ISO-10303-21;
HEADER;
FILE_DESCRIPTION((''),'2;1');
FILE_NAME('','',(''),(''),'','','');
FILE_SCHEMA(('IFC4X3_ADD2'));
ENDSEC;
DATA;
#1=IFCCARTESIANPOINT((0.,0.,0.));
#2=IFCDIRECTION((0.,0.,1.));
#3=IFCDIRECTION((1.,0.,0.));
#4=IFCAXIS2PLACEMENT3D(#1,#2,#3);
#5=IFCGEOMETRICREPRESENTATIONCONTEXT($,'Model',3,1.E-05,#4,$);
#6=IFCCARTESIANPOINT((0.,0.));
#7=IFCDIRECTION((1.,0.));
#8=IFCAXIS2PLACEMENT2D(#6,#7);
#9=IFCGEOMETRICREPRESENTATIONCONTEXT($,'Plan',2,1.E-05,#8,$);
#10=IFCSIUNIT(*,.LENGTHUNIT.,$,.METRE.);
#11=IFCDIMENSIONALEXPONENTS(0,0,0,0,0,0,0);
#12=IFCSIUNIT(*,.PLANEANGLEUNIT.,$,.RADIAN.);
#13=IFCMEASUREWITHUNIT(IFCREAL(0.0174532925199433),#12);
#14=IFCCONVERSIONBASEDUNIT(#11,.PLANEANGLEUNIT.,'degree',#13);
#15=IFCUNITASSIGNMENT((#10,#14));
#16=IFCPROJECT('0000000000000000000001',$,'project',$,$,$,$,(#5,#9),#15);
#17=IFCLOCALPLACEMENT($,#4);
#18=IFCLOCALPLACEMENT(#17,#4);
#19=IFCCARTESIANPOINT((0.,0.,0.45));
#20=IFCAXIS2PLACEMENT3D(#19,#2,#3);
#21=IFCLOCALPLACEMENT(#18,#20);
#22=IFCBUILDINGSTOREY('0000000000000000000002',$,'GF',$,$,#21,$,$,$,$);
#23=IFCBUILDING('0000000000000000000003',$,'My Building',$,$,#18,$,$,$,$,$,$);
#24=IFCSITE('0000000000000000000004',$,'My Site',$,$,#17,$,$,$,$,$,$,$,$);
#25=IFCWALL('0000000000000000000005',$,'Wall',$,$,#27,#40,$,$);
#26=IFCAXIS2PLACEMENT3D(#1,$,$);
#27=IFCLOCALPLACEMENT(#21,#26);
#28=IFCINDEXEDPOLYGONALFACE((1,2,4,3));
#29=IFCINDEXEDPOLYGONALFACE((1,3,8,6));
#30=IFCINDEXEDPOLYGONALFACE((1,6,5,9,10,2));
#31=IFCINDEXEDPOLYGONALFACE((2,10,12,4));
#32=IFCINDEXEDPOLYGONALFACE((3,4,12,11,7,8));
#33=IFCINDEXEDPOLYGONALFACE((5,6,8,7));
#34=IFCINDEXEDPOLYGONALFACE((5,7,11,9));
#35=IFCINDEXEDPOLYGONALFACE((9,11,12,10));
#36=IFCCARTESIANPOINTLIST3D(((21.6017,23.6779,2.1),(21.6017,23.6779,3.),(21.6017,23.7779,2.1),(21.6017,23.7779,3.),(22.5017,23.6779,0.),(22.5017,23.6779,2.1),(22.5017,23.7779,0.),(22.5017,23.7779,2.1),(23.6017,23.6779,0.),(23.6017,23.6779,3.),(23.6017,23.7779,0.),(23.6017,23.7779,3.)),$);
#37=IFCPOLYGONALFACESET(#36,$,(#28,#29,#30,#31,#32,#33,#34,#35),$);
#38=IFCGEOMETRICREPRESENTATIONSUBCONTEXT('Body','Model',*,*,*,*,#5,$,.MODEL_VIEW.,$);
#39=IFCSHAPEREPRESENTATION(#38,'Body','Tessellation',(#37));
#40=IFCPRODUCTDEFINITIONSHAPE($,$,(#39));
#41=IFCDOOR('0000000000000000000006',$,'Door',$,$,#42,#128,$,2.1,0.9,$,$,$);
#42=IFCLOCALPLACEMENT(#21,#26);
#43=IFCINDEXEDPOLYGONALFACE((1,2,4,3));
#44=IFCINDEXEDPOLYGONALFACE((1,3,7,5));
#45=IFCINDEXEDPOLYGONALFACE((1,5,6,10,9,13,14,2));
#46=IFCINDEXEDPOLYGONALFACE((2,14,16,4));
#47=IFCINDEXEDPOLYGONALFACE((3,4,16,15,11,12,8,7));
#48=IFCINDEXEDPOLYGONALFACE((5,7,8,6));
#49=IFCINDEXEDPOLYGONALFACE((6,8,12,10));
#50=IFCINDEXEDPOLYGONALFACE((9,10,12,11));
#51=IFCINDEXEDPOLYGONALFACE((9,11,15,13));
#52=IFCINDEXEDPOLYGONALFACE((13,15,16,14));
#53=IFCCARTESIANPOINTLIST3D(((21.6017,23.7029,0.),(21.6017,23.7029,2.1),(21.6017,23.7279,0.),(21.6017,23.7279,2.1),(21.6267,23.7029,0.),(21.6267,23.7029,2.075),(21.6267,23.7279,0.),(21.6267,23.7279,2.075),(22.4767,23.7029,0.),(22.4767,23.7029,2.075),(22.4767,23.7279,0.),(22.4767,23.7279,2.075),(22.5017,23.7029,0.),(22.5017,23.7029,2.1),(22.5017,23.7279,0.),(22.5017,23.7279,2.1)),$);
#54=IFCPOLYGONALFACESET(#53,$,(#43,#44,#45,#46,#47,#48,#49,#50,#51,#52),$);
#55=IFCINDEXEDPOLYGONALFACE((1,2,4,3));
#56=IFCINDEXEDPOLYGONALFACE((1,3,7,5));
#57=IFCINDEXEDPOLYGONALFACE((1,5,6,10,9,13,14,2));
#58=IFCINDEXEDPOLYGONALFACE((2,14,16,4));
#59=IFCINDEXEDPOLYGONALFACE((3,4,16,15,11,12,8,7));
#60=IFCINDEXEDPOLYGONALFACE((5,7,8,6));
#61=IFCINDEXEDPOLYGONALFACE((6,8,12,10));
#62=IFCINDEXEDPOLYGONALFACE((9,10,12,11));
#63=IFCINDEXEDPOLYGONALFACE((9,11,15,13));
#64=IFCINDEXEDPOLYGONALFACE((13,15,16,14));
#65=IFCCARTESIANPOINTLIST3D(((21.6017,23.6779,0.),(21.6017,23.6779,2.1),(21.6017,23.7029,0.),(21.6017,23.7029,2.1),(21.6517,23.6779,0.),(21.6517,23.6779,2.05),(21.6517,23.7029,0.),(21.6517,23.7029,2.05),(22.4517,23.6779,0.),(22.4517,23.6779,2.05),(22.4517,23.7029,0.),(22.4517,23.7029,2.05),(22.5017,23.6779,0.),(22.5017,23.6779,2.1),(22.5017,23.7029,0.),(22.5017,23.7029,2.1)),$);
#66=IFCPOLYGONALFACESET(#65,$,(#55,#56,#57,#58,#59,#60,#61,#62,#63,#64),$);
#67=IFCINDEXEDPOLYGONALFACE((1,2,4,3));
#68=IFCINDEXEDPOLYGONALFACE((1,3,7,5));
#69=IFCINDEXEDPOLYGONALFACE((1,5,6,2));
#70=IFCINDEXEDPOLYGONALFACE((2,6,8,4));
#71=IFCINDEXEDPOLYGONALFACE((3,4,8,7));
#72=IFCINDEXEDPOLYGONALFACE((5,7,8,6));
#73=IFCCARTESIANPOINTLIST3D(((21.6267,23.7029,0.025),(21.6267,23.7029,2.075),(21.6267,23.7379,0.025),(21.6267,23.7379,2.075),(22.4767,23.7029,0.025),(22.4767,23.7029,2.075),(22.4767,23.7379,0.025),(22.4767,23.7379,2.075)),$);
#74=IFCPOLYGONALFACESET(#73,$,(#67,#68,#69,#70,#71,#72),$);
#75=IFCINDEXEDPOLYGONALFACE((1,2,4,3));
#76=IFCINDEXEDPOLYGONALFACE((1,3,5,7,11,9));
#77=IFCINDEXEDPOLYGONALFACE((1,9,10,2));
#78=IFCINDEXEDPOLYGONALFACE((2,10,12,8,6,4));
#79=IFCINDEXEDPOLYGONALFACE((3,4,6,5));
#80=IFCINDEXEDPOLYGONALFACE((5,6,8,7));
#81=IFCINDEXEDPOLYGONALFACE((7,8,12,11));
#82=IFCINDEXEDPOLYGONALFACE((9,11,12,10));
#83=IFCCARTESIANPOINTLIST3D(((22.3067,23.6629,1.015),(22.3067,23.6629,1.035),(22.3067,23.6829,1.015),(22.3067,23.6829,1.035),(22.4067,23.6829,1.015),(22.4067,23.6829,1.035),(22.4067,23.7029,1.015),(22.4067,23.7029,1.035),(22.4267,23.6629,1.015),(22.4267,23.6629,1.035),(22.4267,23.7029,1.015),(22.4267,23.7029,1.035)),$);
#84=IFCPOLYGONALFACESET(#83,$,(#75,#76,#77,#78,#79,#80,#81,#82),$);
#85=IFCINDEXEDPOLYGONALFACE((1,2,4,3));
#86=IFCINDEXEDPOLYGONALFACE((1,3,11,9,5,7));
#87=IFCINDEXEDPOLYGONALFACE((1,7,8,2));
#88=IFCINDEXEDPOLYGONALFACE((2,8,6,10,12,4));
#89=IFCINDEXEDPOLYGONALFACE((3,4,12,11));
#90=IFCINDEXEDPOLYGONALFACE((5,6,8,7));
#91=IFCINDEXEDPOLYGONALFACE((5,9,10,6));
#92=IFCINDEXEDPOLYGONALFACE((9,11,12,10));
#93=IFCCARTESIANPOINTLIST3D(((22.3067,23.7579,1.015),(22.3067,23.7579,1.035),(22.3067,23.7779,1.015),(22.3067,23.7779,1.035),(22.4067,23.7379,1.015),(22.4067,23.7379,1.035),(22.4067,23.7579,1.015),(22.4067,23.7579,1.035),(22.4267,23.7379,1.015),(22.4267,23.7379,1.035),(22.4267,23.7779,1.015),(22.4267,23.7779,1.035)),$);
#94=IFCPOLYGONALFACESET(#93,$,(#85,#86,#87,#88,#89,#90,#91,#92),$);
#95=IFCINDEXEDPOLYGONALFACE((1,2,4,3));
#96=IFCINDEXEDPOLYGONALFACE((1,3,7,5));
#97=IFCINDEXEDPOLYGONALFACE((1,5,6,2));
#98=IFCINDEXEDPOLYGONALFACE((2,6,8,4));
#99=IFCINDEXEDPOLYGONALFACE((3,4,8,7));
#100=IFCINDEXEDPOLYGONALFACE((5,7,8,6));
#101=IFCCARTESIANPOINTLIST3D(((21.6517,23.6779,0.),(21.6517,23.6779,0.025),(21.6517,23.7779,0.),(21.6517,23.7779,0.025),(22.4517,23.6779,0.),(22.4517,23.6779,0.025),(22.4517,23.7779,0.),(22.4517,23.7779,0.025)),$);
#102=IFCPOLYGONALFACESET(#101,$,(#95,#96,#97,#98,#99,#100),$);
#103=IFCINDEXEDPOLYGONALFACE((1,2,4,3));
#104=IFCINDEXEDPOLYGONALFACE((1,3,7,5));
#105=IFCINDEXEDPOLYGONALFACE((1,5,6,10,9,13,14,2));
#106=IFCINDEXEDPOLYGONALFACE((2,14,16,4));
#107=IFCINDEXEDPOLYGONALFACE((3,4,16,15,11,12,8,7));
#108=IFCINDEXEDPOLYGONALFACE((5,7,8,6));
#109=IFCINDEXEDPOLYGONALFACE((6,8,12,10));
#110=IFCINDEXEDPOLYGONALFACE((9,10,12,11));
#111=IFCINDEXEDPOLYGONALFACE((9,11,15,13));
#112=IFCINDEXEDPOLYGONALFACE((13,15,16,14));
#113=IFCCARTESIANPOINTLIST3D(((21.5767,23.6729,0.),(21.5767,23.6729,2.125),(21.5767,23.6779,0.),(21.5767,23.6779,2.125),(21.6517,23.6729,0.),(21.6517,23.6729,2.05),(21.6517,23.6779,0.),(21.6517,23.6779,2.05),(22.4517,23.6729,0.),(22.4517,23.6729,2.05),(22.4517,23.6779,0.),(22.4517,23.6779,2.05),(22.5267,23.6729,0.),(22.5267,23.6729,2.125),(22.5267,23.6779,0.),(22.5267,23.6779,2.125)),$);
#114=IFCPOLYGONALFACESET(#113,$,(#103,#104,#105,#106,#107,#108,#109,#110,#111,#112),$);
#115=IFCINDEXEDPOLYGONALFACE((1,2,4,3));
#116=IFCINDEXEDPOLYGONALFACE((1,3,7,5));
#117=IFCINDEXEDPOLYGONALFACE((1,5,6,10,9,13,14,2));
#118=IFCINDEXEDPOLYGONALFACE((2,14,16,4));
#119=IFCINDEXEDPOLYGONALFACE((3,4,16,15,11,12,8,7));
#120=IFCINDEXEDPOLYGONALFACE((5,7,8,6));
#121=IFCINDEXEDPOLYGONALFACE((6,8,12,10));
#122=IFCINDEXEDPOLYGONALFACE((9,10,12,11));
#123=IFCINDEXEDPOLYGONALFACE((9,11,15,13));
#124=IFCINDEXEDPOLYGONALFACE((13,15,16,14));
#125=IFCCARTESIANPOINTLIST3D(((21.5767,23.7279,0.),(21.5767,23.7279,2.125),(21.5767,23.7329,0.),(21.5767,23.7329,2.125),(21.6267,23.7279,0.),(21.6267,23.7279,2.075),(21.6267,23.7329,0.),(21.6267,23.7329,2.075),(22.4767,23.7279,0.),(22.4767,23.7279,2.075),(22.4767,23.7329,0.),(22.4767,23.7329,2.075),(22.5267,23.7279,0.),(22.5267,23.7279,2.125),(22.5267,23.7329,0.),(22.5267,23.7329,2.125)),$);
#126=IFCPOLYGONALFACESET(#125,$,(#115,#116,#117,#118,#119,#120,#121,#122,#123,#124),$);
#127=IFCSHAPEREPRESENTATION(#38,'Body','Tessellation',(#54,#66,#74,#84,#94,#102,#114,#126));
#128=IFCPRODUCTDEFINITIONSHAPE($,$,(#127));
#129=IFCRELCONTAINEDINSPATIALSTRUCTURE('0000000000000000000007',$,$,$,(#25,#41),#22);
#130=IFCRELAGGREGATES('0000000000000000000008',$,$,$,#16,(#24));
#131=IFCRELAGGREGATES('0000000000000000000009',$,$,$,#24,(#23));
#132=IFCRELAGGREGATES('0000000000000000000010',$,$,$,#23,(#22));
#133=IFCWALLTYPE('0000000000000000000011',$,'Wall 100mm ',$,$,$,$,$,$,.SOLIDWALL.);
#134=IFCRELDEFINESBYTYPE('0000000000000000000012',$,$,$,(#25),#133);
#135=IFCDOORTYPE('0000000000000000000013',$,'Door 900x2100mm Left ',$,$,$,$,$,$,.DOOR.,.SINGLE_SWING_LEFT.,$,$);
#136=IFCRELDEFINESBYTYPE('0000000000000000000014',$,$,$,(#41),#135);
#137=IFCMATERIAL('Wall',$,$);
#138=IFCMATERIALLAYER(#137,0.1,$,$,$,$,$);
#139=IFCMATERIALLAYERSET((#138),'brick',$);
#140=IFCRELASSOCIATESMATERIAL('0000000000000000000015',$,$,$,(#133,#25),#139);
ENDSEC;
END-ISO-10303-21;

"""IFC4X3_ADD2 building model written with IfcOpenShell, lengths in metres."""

from ifc_helpers import new_model, entity, si_unit, converted_unit, frame, origin_with_axes, origin_2d_with_axis, place, context, subcontext, project, spatial, line, indexed_curve, outline, extrude, shape, source, transform, mapped, material, layer, layer_set, layer_usage, type_object, type_shapes, element, fill, save


model = new_model("IFC4X3_ADD2")

# Units and contexts
model_context = context("Model", 3, precision=1e-05, world=origin_with_axes())
plan_context = context("Plan", 2, precision=1e-05, world=origin_2d_with_axis())
body_context_1 = subcontext(model_context, "Body", "Model", "MODEL_VIEW")
body_context_2 = subcontext(plan_context, "Body", "Plan", "PLAN_VIEW")
ifc_project = project(units=[si_unit("LENGTHUNIT", "METRE"), converted_unit("PLANEANGLEUNIT", "degree", entity("IfcReal", 0.0174532925199433), si_unit("PLANEANGLEUNIT", "RADIAN"), dimensions=[0, 0, 0, 0, 0, 0, 0])], contexts=[model_context, plan_context])

# Site, building, storey
site_placement = place(None, origin_with_axes())
site = spatial("IfcSite", under=ifc_project, at=site_placement, Name="My Site")
building_placement = place(site_placement, origin_with_axes())
building = spatial("IfcBuilding", under=site, at=building_placement, Name="My Building")
storey_placement = place(building_placement, frame((0.0, 0.0, 0.45), z_axis=(0.0, 0.0, 1.0), x_axis=(1.0, 0.0, 0.0)))
storey = spatial("IfcBuildingStorey", under=building, at=storey_placement, Name="GF")

# Shared definitions
ifc_material_1 = material(Name="Wall")

# Wall, opening, door
ifc_layer_1 = layer(ifc_material_1, 0.1)
ifc_layer_set_1 = layer_set([ifc_layer_1], Name="brick")
ifc_layer_usage_1 = layer_usage(ifc_layer_set_1, "AXIS2", "POSITIVE", 0.0)
wall_type_1 = type_object("IfcWallType", Name="Wall 100mm ", PredefinedType="SOLIDWALL", material=ifc_layer_set_1)
wall_1_placement = place(storey_placement, frame((21.6017, 23.6779, 0.0), z_axis=(0.0, 0.0, 1.0), x_axis=(1.0, 0.0, 0.0)))
wall_1 = element("IfcWall", 1, at=wall_1_placement, inside=storey, type_object=wall_type_1, material=ifc_layer_usage_1, Name="Wall", context=body_context_1, shape_type="SweptSolid", body=[
    extrude(outline(indexed_curve([(0.0, 0.0), (0.0, 0.1), (2.0, 0.1), (2.0, 0.0), (0.0, 0.0)], self_intersect=False)), origin_with_axes(), (0.0, 0.0, 1.0), 3.0),
])
shared_shape_1 = source(origin_with_axes(), body_context_1, "Body", "SweptSolid", [
    extrude(outline(indexed_curve([(0.0, 0.0), (0.9, 0.0), (0.9, 2.1), (0.0, 2.1)], segments=[line(1, 2, 3, 4, 1)])), frame((0.0, -0.6, 0.0), z_axis=(0.0, -1.0, 0.0), x_axis=(1.0, 0.0, 0.0)), (0.0, 0.0, -1.0), 1.2),
])
opening_1_placement = place(wall_1_placement, frame((0.0, 0.0, 0.0), z_axis=(0.0, 0.0, 1.0), x_axis=(1.0, 0.0, 0.0)))
opening_1 = element("IfcOpeningElement", 2, at=opening_1_placement, cuts=wall_1, PredefinedType="OPENING", context=body_context_1, shape_type="MappedRepresentation", body=[
    mapped(shared_shape_1, transform((0.0, 0.0, 0.0), x_axis=(1.0, 0.0, 0.0), y_axis=(0.0, 1.0, 0.0), z_axis=(0.0, 0.0, 1.0), scale=1.0)),
])
door_type = type_object("IfcDoorType", Name="Door 900x2100mm Left ", OperationType="SINGLE_SWING_LEFT", PredefinedType="DOOR")
shared_shape_2 = source(origin_with_axes(), body_context_1, "Body", "SweptSolid", [
    extrude(outline(indexed_curve([(0.0, 0.0), (0.0, 2.1), (0.9, 2.1), (0.9, 0.0), (0.875, 0.0), (0.875, 2.075), (0.025, 2.075), (0.025, 0.0)], segments=[line(1, 2, 3, 4, 5, 6, 7, 8, 1)])), frame((0.0, 0.025, 0.0), z_axis=(0.0, -1.0, 0.0), x_axis=(1.0, 0.0, 0.0)), (0.0, 0.0, -1.0), 0.025),
    extrude(outline(indexed_curve([(0.0, 0.0), (0.0, 2.1), (0.9, 2.1), (0.9, 0.0), (0.85, 0.0), (0.85, 2.05), (0.05, 2.05), (0.05, 0.0)], segments=[line(1, 2, 3, 4, 5, 6, 7, 8, 1)])), frame((0.0, 0.0, 0.0), z_axis=(0.0, -1.0, 0.0), x_axis=(1.0, 0.0, 0.0)), (0.0, 0.0, -1.0), 0.025),
    extrude(outline(indexed_curve([(0.0, 0.0), (0.85, 0.0), (0.85, 0.035), (0.0, 0.035)], segments=[line(1, 2, 3, 4, 1)])), frame((0.025, 0.025, 0.025), z_axis=(0.0, 0.0, 1.0), x_axis=(1.0, 0.0, 0.0)), (0.0, 0.0, 1.0), 2.05),
    extrude(outline(indexed_curve([(0.0, 0.0), (0.0, -0.04), (-0.12, -0.04), (-0.12, -0.02), (-0.02, -0.02), (-0.02, 0.0)], segments=[line(1, 2, 3, 4, 5, 6, 1)])), frame((0.825, 0.025, 1.015), z_axis=(0.0, 0.0, 1.0), x_axis=(1.0, 0.0, 0.0)), (0.0, 0.0, 1.0), 0.02),
    extrude(outline(indexed_curve([(0.0, 0.0), (0.0, 0.04), (-0.12, 0.04), (-0.12, 0.02), (-0.02, 0.02), (-0.02, 0.0)], segments=[line(1, 2, 3, 4, 5, 6, 1)])), frame((0.825, 0.06, 1.015), z_axis=(0.0, 0.0, 1.0), x_axis=(1.0, 0.0, 0.0)), (0.0, 0.0, 1.0), 0.02),
    extrude(outline(indexed_curve([(0.0, 0.0), (0.8, 0.0), (0.8, 0.1), (0.0, 0.1)], segments=[line(1, 2, 3, 4, 1)])), frame((0.05, 0.0, 0.0), z_axis=(0.0, 0.0, 1.0), x_axis=(1.0, 0.0, 0.0)), (0.0, 0.0, 1.0), 0.025),
    extrude(outline(indexed_curve([(0.0, 0.0), (0.0, 2.125), (0.95, 2.125), (0.95, 0.0), (0.875, 0.0), (0.875, 2.05), (0.075, 2.05), (0.075, 0.0)], segments=[line(1, 2, 3, 4, 5, 6, 7, 8, 1)])), frame((-0.025, -0.005, 0.0), z_axis=(0.0, -1.0, 0.0), x_axis=(1.0, 0.0, 0.0)), (0.0, 0.0, -1.0), 0.005),
    extrude(outline(indexed_curve([(0.0, 0.0), (0.0, 2.125), (0.95, 2.125), (0.95, 0.0), (0.9, 0.0), (0.9, 2.075), (0.05, 2.075), (0.05, 0.0)], segments=[line(1, 2, 3, 4, 5, 6, 7, 8, 1)])), frame((-0.025, 0.05, 0.0), z_axis=(0.0, -1.0, 0.0), x_axis=(1.0, 0.0, 0.0)), (0.0, 0.0, -1.0), 0.005),
])
shared_shape_3 = source(origin_with_axes(), body_context_2, "Body", "Curve2D", [
    entity("IfcIndexedPolyCurve", entity("IfcCartesianPointList2D", [[0.0, 0.0], [0.0, 0.05], [0.025, 0.05], [0.025, 0.025], [0.05, 0.025], [0.05, 0.0]]), [entity("IfcLineIndex", [1, 2, 3, 4, 5, 6, 1])]),
    entity("IfcIndexedPolyCurve", entity("IfcCartesianPointList2D", [[0.9, 0.0], [0.9, 0.05], [0.875, 0.05], [0.875, 0.025], [0.85, 0.025], [0.85, 0.0]]), [entity("IfcLineIndex", [1, 2, 3, 4, 5, 6, 1])]),
    entity("IfcTrimmedCurve", entity("IfcEllipse", entity("IfcAxis2Placement2D", entity("IfcCartesianPoint", [0.06, 0.05]), entity("IfcDirection", [1.0, 0.0])), 0.815, 0.85), [entity("IfcCartesianPoint", [0.875, 0.05])], [entity("IfcCartesianPoint", [0.06, 0.9])], True, "CARTESIAN"),
    entity("IfcIndexedPolyCurve", entity("IfcCartesianPointList2D", [[0.025, 0.05], [0.06, 0.05], [0.06, 0.9], [0.025, 0.9]]), [entity("IfcLineIndex", [1, 2, 3, 4, 1])]),
])
type_shapes(door_type, [shared_shape_2, shared_shape_3])
door_placement = place(opening_1_placement, origin_with_axes())
door = element("IfcDoor", 3, at=door_placement, inside=storey, type_object=door_type, Name="Door", OverallHeight=2.1, OverallWidth=0.9, shapes=[
    shape(body_context_1, "Body", "MappedRepresentation", [mapped(shared_shape_2, transform((0.0, 0.0, 0.0), x_axis=(1.0, 0.0, 0.0), y_axis=(0.0, 1.0, 0.0), z_axis=(0.0, 0.0, 1.0), scale=1.0))]),
    shape(body_context_2, "Body", "MappedRepresentation", [mapped(shared_shape_3, transform((0.0, 0.0, 0.0), x_axis=(1.0, 0.0, 0.0), y_axis=(0.0, 1.0, 0.0), z_axis=(0.0, 0.0, 1.0), scale=1.0))]),
])
fill(opening_1, door)

save(model, "model.ifc")
